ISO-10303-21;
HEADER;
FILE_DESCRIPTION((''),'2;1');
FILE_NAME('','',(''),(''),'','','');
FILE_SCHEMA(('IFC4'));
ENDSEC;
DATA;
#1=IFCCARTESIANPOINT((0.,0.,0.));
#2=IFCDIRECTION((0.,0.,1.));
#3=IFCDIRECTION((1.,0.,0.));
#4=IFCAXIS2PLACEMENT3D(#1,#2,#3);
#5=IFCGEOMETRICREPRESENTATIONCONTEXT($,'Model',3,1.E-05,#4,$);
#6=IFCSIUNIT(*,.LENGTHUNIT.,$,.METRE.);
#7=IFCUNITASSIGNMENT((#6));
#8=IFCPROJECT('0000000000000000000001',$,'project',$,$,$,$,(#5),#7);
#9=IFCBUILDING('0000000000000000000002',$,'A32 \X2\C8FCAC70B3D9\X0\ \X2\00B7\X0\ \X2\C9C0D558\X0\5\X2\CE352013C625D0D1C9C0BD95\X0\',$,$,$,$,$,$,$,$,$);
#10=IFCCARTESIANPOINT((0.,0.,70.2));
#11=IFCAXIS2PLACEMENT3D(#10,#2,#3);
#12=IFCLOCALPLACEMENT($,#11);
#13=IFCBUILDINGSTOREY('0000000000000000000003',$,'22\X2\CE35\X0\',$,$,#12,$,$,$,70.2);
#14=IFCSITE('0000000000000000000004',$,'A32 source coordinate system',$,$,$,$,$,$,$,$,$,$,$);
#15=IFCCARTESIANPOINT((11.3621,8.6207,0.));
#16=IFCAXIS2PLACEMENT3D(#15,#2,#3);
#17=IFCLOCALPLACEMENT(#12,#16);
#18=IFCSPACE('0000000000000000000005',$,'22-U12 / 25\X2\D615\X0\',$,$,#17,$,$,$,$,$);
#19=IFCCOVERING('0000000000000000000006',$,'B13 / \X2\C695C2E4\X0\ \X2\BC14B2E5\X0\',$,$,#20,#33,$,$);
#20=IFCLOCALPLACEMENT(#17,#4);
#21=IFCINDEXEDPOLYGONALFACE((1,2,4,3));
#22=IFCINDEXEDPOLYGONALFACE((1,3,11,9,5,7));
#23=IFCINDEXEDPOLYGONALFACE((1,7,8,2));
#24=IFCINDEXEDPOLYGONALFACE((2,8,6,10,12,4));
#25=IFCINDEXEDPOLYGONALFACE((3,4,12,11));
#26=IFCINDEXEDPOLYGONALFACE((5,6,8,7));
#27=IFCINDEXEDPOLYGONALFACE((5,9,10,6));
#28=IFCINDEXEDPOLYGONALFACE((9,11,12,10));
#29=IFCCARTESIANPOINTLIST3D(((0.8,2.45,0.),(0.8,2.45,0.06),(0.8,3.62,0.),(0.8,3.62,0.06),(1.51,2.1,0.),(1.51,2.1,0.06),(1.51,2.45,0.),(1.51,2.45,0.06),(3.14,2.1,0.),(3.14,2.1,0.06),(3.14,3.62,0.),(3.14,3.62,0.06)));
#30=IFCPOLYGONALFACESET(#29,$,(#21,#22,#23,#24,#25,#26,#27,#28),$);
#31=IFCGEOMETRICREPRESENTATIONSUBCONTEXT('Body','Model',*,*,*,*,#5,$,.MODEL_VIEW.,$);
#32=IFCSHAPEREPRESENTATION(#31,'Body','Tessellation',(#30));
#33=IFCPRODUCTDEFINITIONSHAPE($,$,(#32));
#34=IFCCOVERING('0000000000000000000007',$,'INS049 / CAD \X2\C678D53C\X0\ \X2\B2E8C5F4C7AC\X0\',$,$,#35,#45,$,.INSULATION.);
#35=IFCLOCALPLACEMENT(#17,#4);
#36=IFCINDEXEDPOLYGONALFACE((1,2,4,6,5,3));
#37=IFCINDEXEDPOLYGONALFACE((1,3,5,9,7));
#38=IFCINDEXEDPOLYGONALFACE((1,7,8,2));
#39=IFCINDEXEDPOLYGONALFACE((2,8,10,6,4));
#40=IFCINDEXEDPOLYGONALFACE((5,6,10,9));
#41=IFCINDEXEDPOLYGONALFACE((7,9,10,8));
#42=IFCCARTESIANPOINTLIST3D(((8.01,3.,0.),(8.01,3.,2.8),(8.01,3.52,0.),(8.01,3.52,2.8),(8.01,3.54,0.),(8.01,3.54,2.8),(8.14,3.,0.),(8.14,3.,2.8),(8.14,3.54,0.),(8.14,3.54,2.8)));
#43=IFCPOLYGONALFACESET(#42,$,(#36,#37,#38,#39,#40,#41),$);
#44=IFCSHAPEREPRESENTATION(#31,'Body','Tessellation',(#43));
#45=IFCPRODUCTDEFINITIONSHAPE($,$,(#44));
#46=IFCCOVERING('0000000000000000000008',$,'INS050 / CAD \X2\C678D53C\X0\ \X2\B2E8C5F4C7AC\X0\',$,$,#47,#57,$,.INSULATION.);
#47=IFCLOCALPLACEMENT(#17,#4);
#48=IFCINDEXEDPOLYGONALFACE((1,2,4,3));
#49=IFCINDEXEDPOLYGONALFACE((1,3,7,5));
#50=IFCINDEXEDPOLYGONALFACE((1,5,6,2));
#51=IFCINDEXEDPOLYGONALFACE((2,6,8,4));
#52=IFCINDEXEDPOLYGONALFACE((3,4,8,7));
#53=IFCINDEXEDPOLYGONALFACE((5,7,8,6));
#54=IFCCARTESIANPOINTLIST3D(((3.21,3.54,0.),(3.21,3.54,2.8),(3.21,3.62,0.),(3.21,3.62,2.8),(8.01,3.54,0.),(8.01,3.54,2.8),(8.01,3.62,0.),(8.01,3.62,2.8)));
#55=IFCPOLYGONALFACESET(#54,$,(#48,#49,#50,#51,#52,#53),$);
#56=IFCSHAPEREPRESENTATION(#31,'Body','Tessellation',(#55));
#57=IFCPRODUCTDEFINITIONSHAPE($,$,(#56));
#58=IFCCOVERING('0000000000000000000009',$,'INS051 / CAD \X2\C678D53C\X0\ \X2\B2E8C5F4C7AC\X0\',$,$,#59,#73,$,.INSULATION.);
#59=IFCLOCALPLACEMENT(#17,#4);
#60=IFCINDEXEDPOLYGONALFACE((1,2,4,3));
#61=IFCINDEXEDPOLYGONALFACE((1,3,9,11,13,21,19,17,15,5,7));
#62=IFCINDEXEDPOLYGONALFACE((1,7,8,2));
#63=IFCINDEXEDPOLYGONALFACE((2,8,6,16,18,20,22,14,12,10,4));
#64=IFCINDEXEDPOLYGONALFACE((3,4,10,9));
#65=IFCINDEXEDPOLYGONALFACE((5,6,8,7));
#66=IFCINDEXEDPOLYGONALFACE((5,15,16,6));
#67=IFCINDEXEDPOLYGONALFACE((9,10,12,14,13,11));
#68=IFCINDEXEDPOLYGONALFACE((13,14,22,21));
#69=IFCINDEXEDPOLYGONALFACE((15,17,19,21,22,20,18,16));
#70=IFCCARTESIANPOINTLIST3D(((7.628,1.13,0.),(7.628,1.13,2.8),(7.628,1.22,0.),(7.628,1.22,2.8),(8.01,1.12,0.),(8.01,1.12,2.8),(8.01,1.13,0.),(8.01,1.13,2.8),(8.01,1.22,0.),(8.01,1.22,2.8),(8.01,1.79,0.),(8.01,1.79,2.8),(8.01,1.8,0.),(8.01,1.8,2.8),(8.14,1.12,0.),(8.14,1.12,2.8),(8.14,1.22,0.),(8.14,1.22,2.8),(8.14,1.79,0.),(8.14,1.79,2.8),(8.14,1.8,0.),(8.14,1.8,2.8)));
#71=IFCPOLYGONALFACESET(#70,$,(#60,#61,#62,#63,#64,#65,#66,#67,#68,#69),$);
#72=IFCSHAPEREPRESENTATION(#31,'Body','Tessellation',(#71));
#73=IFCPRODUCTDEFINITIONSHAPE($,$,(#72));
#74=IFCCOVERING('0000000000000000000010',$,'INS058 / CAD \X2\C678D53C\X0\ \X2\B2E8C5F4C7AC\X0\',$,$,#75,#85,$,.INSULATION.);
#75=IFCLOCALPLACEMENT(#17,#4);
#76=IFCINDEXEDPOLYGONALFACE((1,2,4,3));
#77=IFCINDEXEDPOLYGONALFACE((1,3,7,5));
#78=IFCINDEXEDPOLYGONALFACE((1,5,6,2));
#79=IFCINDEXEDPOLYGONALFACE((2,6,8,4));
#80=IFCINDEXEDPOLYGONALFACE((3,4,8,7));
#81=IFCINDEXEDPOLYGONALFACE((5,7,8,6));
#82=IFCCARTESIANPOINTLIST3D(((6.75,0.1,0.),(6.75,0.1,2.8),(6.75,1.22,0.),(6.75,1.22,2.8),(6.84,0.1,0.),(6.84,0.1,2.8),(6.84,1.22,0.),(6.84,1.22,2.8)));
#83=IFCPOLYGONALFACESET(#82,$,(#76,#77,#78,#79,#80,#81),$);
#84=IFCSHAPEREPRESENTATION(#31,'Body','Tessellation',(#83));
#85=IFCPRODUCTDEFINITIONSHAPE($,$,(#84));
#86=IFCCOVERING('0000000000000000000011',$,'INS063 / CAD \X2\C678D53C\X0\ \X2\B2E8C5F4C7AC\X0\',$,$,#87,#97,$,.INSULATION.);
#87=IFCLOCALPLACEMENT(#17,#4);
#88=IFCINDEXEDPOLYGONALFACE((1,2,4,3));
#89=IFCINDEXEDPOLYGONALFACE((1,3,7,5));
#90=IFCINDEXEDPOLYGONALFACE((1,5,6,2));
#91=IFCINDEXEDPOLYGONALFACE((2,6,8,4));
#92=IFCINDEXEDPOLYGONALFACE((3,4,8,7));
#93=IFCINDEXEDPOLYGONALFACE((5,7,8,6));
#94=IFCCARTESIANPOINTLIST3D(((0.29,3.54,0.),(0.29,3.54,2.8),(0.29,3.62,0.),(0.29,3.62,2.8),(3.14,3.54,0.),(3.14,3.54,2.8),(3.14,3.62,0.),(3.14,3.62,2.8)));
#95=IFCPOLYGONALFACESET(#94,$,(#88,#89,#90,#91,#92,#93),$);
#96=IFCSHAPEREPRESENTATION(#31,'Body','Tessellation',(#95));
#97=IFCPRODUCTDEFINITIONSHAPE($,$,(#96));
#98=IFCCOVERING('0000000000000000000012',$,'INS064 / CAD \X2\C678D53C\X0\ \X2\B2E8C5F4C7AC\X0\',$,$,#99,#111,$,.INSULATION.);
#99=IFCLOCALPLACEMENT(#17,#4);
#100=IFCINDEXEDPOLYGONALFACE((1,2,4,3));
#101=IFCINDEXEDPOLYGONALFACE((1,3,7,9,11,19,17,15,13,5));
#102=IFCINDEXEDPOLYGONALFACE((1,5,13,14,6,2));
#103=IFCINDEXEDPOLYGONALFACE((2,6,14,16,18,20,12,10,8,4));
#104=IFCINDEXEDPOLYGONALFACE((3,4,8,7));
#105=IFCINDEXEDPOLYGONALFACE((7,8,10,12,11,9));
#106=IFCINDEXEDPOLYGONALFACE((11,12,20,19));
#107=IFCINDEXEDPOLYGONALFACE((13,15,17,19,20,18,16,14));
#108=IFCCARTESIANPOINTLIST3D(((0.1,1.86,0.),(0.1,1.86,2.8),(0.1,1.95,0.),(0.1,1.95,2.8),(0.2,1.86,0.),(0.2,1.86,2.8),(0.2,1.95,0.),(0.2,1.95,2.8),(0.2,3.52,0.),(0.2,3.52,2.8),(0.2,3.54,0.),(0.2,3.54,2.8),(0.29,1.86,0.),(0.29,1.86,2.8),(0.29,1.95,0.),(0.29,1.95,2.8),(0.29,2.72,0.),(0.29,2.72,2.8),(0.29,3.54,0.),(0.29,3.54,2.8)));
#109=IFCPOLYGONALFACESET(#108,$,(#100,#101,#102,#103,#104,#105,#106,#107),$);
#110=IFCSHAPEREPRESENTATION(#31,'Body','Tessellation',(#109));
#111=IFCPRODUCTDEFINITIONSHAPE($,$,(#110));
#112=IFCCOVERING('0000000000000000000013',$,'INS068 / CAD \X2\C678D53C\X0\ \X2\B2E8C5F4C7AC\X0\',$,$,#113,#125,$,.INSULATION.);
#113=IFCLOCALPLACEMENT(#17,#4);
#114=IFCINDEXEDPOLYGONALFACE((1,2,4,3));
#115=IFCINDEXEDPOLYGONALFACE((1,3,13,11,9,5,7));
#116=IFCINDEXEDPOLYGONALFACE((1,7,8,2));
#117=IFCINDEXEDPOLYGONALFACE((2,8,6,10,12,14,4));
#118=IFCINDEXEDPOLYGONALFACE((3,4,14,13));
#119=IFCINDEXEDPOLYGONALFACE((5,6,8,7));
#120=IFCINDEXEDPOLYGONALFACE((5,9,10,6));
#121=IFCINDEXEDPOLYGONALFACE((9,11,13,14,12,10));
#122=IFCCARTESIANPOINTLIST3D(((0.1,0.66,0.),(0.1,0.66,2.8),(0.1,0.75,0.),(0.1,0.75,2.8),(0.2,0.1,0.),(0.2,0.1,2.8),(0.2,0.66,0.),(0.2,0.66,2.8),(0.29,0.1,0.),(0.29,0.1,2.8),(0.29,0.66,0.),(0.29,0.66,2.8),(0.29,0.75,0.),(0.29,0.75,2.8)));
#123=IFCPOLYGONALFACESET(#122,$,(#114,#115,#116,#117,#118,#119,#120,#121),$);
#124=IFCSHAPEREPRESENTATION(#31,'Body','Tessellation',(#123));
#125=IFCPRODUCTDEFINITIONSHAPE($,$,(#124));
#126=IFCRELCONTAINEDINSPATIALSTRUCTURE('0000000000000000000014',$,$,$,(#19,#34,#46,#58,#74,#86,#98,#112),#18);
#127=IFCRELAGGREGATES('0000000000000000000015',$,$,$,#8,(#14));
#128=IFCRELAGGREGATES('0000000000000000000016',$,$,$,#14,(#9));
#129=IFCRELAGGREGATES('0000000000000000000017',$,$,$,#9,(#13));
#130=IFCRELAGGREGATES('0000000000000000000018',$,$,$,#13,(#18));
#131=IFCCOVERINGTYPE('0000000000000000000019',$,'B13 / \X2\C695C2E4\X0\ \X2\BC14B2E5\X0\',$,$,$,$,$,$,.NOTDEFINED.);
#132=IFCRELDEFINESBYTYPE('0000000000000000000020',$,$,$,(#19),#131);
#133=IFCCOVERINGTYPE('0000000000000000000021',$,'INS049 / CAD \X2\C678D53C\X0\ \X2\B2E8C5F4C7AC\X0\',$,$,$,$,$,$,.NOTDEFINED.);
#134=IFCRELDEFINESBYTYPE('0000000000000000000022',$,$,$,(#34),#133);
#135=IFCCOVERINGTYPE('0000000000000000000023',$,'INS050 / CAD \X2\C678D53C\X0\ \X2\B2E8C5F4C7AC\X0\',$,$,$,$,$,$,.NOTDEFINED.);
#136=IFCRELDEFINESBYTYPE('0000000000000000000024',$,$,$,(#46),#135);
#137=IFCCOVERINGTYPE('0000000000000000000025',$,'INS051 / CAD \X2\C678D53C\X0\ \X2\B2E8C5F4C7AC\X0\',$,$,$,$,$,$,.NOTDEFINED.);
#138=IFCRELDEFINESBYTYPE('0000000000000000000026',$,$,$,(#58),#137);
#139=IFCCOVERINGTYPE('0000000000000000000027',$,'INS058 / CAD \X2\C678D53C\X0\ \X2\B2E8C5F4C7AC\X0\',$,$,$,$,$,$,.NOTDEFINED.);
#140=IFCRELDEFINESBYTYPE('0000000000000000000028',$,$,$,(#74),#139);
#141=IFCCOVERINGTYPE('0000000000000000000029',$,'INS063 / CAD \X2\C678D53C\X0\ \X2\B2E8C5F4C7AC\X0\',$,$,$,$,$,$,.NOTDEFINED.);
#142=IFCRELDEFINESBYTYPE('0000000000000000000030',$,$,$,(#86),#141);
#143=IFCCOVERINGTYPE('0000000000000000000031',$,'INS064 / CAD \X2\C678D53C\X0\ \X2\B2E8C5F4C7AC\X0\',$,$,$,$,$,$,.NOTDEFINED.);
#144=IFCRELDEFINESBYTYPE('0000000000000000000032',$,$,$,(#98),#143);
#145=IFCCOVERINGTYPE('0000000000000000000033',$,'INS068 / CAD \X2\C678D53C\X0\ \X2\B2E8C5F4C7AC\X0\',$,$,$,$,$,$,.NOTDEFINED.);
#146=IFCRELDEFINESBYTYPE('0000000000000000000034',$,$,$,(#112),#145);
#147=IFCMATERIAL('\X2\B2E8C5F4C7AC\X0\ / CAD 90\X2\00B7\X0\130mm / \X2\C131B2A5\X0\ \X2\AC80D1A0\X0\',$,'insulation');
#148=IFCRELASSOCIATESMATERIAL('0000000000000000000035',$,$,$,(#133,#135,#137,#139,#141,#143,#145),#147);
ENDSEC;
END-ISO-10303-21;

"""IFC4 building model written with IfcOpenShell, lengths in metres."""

from ifc_helpers import new_model, si_unit, frame, origin, origin_with_axes, place, context, subcontext, project, spatial, polyline, outline, extrude, source, transform, mapped, material, type_object, type_shapes, element, save


model = new_model("IFC4")

# Units and contexts
model_context = context("Model", 3, precision=1e-05, world=origin_with_axes())
body_context = subcontext(model_context, "Body", "Model", "MODEL_VIEW")
ifc_project = project(units=[si_unit("LENGTHUNIT", "METRE")], contexts=[model_context])

# Site, building, storey
storey_placement = place(None, frame((0.0, 0.0, 70.2), z_axis=(0.0, 0.0, 1.0), x_axis=(1.0, 0.0, 0.0)))
space_1_placement = place(storey_placement, frame((11.3621, 8.6207, 0.0), z_axis=(0.0, 0.0, 1.0), x_axis=(1.0, 0.0, 0.0)))
site = spatial("IfcSite", under=ifc_project, Name="A32 source coordinate system")
building = spatial("IfcBuilding", under=site, Name="A32 주거동 · 지하5층–옥탑지붕")
storey = spatial("IfcBuildingStorey", under=building, at=storey_placement, Name="22층", Elevation=70.2)

# Shared definitions
space_1 = spatial("IfcSpace", under=storey, at=space_1_placement, Name="22-U12 / 25형")

# Coverings
covering_type_1 = type_object("IfcCoveringType", Name="B13 / 욕실 바닥", PredefinedType="NOTDEFINED")
shared_shape_1 = source(origin(), body_context, "Body", "SweptSolid", [
    extrude(outline(polyline([(3.14, 2.1), (1.51, 2.1), (1.51, 2.45), (0.8, 2.45), (0.8, 3.62), (3.14, 3.62), (3.14, 2.1)])), origin(), (0.0, 0.0, 1.0), 0.06),
])
type_shapes(covering_type_1, [shared_shape_1])
covering_1_placement = place(space_1_placement, origin_with_axes())
element("IfcCovering", 1, at=covering_1_placement, inside=space_1, type_object=covering_type_1, Name="B13 / 욕실 바닥", context=body_context, shape_type="MappedRepresentation", body=[
    mapped(shared_shape_1, transform((0.0, 0.0, 0.0), scale=1.0)),
])
ifc_material = material(Name="단열재 / CAD 90·130mm / 성능 검토", Category="insulation")
covering_type_2 = type_object("IfcCoveringType", Name="INS049 / CAD 외피 단열재", PredefinedType="NOTDEFINED", material=ifc_material)
shared_shape_2 = source(origin(), body_context, "Body", "SweptSolid", [
    extrude(outline(polyline([(8.01, 3.54), (8.14, 3.54), (8.14, 3.0), (8.01, 3.0), (8.01, 3.52), (8.01, 3.54)])), origin(), (0.0, 0.0, 1.0), 2.8),
])
type_shapes(covering_type_2, [shared_shape_2])
covering_2_placement = place(space_1_placement, origin_with_axes())
element("IfcCovering", 2, at=covering_2_placement, inside=space_1, type_object=covering_type_2, Name="INS049 / CAD 외피 단열재", PredefinedType="INSULATION", context=body_context, shape_type="MappedRepresentation", body=[
    mapped(shared_shape_2, transform((0.0, 0.0, 0.0), scale=1.0)),
])
covering_type_3 = type_object("IfcCoveringType", Name="INS050 / CAD 외피 단열재", PredefinedType="NOTDEFINED", material=ifc_material)
shared_shape_3 = source(origin(), body_context, "Body", "SweptSolid", [
    extrude(outline(polyline([(8.01, 3.54), (3.21, 3.54), (3.21, 3.62), (8.01, 3.62), (8.01, 3.54)])), origin(), (0.0, 0.0, 1.0), 2.8),
])
type_shapes(covering_type_3, [shared_shape_3])
covering_3_placement = place(space_1_placement, origin_with_axes())
element("IfcCovering", 3, at=covering_3_placement, inside=space_1, type_object=covering_type_3, Name="INS050 / CAD 외피 단열재", PredefinedType="INSULATION", context=body_context, shape_type="MappedRepresentation", body=[
    mapped(shared_shape_3, transform((0.0, 0.0, 0.0), scale=1.0)),
])
covering_type_4 = type_object("IfcCoveringType", Name="INS051 / CAD 외피 단열재", PredefinedType="NOTDEFINED", material=ifc_material)
shared_shape_4 = source(origin(), body_context, "Body", "SweptSolid", [
    extrude(outline(polyline([(8.14, 1.12), (8.01, 1.12), (8.01, 1.13), (7.628, 1.13), (7.628, 1.22), (8.01, 1.22), (8.01, 1.79), (8.01, 1.8), (8.14, 1.8), (8.14, 1.79), (8.14, 1.22), (8.14, 1.12)])), origin(), (0.0, 0.0, 1.0), 2.8),
])
type_shapes(covering_type_4, [shared_shape_4])
covering_4_placement = place(space_1_placement, origin_with_axes())
element("IfcCovering", 4, at=covering_4_placement, inside=space_1, type_object=covering_type_4, Name="INS051 / CAD 외피 단열재", PredefinedType="INSULATION", context=body_context, shape_type="MappedRepresentation", body=[
    mapped(shared_shape_4, transform((0.0, 0.0, 0.0), scale=1.0)),
])
covering_type_5 = type_object("IfcCoveringType", Name="INS058 / CAD 외피 단열재", PredefinedType="NOTDEFINED", material=ifc_material)
shared_shape_5 = source(origin(), body_context, "Body", "SweptSolid", [
    extrude(outline(polyline([(6.75, 0.1), (6.75, 1.22), (6.84, 1.22), (6.84, 0.1), (6.75, 0.1)])), origin(), (0.0, 0.0, 1.0), 2.8),
])
type_shapes(covering_type_5, [shared_shape_5])
covering_5_placement = place(space_1_placement, origin_with_axes())
element("IfcCovering", 5, at=covering_5_placement, inside=space_1, type_object=covering_type_5, Name="INS058 / CAD 외피 단열재", PredefinedType="INSULATION", context=body_context, shape_type="MappedRepresentation", body=[
    mapped(shared_shape_5, transform((0.0, 0.0, 0.0), scale=1.0)),
])
covering_type_6 = type_object("IfcCoveringType", Name="INS063 / CAD 외피 단열재", PredefinedType="NOTDEFINED", material=ifc_material)
shared_shape_6 = source(origin(), body_context, "Body", "SweptSolid", [
    extrude(outline(polyline([(0.29, 3.54), (0.29, 3.62), (3.14, 3.62), (3.14, 3.54), (0.29, 3.54)])), origin(), (0.0, 0.0, 1.0), 2.8),
])
type_shapes(covering_type_6, [shared_shape_6])
covering_6_placement = place(space_1_placement, origin_with_axes())
element("IfcCovering", 6, at=covering_6_placement, inside=space_1, type_object=covering_type_6, Name="INS063 / CAD 외피 단열재", PredefinedType="INSULATION", context=body_context, shape_type="MappedRepresentation", body=[
    mapped(shared_shape_6, transform((0.0, 0.0, 0.0), scale=1.0)),
])
covering_type_7 = type_object("IfcCoveringType", Name="INS064 / CAD 외피 단열재", PredefinedType="NOTDEFINED", material=ifc_material)
shared_shape_7 = source(origin(), body_context, "Body", "SweptSolid", [
    extrude(outline(polyline([(0.1, 1.86), (0.1, 1.95), (0.2, 1.95), (0.2, 3.52), (0.2, 3.54), (0.29, 3.54), (0.29, 2.72), (0.29, 1.95), (0.29, 1.86), (0.2, 1.86), (0.1, 1.86)])), origin(), (0.0, 0.0, 1.0), 2.8),
])
type_shapes(covering_type_7, [shared_shape_7])
covering_7_placement = place(space_1_placement, origin_with_axes())
element("IfcCovering", 7, at=covering_7_placement, inside=space_1, type_object=covering_type_7, Name="INS064 / CAD 외피 단열재", PredefinedType="INSULATION", context=body_context, shape_type="MappedRepresentation", body=[
    mapped(shared_shape_7, transform((0.0, 0.0, 0.0), scale=1.0)),
])
covering_type_8 = type_object("IfcCoveringType", Name="INS068 / CAD 외피 단열재", PredefinedType="NOTDEFINED", material=ifc_material)
shared_shape_8 = source(origin(), body_context, "Body", "SweptSolid", [
    extrude(outline(polyline([(0.2, 0.1), (0.2, 0.66), (0.1, 0.66), (0.1, 0.75), (0.29, 0.75), (0.29, 0.66), (0.29, 0.1), (0.2, 0.1)])), origin(), (0.0, 0.0, 1.0), 2.8),
])
type_shapes(covering_type_8, [shared_shape_8])
covering_8_placement = place(space_1_placement, origin_with_axes())
element("IfcCovering", 8, at=covering_8_placement, inside=space_1, type_object=covering_type_8, Name="INS068 / CAD 외피 단열재", PredefinedType="INSULATION", context=body_context, shape_type="MappedRepresentation", body=[
    mapped(shared_shape_8, transform((0.0, 0.0, 0.0), scale=1.0)),
])

save(model, "model.ifc")
